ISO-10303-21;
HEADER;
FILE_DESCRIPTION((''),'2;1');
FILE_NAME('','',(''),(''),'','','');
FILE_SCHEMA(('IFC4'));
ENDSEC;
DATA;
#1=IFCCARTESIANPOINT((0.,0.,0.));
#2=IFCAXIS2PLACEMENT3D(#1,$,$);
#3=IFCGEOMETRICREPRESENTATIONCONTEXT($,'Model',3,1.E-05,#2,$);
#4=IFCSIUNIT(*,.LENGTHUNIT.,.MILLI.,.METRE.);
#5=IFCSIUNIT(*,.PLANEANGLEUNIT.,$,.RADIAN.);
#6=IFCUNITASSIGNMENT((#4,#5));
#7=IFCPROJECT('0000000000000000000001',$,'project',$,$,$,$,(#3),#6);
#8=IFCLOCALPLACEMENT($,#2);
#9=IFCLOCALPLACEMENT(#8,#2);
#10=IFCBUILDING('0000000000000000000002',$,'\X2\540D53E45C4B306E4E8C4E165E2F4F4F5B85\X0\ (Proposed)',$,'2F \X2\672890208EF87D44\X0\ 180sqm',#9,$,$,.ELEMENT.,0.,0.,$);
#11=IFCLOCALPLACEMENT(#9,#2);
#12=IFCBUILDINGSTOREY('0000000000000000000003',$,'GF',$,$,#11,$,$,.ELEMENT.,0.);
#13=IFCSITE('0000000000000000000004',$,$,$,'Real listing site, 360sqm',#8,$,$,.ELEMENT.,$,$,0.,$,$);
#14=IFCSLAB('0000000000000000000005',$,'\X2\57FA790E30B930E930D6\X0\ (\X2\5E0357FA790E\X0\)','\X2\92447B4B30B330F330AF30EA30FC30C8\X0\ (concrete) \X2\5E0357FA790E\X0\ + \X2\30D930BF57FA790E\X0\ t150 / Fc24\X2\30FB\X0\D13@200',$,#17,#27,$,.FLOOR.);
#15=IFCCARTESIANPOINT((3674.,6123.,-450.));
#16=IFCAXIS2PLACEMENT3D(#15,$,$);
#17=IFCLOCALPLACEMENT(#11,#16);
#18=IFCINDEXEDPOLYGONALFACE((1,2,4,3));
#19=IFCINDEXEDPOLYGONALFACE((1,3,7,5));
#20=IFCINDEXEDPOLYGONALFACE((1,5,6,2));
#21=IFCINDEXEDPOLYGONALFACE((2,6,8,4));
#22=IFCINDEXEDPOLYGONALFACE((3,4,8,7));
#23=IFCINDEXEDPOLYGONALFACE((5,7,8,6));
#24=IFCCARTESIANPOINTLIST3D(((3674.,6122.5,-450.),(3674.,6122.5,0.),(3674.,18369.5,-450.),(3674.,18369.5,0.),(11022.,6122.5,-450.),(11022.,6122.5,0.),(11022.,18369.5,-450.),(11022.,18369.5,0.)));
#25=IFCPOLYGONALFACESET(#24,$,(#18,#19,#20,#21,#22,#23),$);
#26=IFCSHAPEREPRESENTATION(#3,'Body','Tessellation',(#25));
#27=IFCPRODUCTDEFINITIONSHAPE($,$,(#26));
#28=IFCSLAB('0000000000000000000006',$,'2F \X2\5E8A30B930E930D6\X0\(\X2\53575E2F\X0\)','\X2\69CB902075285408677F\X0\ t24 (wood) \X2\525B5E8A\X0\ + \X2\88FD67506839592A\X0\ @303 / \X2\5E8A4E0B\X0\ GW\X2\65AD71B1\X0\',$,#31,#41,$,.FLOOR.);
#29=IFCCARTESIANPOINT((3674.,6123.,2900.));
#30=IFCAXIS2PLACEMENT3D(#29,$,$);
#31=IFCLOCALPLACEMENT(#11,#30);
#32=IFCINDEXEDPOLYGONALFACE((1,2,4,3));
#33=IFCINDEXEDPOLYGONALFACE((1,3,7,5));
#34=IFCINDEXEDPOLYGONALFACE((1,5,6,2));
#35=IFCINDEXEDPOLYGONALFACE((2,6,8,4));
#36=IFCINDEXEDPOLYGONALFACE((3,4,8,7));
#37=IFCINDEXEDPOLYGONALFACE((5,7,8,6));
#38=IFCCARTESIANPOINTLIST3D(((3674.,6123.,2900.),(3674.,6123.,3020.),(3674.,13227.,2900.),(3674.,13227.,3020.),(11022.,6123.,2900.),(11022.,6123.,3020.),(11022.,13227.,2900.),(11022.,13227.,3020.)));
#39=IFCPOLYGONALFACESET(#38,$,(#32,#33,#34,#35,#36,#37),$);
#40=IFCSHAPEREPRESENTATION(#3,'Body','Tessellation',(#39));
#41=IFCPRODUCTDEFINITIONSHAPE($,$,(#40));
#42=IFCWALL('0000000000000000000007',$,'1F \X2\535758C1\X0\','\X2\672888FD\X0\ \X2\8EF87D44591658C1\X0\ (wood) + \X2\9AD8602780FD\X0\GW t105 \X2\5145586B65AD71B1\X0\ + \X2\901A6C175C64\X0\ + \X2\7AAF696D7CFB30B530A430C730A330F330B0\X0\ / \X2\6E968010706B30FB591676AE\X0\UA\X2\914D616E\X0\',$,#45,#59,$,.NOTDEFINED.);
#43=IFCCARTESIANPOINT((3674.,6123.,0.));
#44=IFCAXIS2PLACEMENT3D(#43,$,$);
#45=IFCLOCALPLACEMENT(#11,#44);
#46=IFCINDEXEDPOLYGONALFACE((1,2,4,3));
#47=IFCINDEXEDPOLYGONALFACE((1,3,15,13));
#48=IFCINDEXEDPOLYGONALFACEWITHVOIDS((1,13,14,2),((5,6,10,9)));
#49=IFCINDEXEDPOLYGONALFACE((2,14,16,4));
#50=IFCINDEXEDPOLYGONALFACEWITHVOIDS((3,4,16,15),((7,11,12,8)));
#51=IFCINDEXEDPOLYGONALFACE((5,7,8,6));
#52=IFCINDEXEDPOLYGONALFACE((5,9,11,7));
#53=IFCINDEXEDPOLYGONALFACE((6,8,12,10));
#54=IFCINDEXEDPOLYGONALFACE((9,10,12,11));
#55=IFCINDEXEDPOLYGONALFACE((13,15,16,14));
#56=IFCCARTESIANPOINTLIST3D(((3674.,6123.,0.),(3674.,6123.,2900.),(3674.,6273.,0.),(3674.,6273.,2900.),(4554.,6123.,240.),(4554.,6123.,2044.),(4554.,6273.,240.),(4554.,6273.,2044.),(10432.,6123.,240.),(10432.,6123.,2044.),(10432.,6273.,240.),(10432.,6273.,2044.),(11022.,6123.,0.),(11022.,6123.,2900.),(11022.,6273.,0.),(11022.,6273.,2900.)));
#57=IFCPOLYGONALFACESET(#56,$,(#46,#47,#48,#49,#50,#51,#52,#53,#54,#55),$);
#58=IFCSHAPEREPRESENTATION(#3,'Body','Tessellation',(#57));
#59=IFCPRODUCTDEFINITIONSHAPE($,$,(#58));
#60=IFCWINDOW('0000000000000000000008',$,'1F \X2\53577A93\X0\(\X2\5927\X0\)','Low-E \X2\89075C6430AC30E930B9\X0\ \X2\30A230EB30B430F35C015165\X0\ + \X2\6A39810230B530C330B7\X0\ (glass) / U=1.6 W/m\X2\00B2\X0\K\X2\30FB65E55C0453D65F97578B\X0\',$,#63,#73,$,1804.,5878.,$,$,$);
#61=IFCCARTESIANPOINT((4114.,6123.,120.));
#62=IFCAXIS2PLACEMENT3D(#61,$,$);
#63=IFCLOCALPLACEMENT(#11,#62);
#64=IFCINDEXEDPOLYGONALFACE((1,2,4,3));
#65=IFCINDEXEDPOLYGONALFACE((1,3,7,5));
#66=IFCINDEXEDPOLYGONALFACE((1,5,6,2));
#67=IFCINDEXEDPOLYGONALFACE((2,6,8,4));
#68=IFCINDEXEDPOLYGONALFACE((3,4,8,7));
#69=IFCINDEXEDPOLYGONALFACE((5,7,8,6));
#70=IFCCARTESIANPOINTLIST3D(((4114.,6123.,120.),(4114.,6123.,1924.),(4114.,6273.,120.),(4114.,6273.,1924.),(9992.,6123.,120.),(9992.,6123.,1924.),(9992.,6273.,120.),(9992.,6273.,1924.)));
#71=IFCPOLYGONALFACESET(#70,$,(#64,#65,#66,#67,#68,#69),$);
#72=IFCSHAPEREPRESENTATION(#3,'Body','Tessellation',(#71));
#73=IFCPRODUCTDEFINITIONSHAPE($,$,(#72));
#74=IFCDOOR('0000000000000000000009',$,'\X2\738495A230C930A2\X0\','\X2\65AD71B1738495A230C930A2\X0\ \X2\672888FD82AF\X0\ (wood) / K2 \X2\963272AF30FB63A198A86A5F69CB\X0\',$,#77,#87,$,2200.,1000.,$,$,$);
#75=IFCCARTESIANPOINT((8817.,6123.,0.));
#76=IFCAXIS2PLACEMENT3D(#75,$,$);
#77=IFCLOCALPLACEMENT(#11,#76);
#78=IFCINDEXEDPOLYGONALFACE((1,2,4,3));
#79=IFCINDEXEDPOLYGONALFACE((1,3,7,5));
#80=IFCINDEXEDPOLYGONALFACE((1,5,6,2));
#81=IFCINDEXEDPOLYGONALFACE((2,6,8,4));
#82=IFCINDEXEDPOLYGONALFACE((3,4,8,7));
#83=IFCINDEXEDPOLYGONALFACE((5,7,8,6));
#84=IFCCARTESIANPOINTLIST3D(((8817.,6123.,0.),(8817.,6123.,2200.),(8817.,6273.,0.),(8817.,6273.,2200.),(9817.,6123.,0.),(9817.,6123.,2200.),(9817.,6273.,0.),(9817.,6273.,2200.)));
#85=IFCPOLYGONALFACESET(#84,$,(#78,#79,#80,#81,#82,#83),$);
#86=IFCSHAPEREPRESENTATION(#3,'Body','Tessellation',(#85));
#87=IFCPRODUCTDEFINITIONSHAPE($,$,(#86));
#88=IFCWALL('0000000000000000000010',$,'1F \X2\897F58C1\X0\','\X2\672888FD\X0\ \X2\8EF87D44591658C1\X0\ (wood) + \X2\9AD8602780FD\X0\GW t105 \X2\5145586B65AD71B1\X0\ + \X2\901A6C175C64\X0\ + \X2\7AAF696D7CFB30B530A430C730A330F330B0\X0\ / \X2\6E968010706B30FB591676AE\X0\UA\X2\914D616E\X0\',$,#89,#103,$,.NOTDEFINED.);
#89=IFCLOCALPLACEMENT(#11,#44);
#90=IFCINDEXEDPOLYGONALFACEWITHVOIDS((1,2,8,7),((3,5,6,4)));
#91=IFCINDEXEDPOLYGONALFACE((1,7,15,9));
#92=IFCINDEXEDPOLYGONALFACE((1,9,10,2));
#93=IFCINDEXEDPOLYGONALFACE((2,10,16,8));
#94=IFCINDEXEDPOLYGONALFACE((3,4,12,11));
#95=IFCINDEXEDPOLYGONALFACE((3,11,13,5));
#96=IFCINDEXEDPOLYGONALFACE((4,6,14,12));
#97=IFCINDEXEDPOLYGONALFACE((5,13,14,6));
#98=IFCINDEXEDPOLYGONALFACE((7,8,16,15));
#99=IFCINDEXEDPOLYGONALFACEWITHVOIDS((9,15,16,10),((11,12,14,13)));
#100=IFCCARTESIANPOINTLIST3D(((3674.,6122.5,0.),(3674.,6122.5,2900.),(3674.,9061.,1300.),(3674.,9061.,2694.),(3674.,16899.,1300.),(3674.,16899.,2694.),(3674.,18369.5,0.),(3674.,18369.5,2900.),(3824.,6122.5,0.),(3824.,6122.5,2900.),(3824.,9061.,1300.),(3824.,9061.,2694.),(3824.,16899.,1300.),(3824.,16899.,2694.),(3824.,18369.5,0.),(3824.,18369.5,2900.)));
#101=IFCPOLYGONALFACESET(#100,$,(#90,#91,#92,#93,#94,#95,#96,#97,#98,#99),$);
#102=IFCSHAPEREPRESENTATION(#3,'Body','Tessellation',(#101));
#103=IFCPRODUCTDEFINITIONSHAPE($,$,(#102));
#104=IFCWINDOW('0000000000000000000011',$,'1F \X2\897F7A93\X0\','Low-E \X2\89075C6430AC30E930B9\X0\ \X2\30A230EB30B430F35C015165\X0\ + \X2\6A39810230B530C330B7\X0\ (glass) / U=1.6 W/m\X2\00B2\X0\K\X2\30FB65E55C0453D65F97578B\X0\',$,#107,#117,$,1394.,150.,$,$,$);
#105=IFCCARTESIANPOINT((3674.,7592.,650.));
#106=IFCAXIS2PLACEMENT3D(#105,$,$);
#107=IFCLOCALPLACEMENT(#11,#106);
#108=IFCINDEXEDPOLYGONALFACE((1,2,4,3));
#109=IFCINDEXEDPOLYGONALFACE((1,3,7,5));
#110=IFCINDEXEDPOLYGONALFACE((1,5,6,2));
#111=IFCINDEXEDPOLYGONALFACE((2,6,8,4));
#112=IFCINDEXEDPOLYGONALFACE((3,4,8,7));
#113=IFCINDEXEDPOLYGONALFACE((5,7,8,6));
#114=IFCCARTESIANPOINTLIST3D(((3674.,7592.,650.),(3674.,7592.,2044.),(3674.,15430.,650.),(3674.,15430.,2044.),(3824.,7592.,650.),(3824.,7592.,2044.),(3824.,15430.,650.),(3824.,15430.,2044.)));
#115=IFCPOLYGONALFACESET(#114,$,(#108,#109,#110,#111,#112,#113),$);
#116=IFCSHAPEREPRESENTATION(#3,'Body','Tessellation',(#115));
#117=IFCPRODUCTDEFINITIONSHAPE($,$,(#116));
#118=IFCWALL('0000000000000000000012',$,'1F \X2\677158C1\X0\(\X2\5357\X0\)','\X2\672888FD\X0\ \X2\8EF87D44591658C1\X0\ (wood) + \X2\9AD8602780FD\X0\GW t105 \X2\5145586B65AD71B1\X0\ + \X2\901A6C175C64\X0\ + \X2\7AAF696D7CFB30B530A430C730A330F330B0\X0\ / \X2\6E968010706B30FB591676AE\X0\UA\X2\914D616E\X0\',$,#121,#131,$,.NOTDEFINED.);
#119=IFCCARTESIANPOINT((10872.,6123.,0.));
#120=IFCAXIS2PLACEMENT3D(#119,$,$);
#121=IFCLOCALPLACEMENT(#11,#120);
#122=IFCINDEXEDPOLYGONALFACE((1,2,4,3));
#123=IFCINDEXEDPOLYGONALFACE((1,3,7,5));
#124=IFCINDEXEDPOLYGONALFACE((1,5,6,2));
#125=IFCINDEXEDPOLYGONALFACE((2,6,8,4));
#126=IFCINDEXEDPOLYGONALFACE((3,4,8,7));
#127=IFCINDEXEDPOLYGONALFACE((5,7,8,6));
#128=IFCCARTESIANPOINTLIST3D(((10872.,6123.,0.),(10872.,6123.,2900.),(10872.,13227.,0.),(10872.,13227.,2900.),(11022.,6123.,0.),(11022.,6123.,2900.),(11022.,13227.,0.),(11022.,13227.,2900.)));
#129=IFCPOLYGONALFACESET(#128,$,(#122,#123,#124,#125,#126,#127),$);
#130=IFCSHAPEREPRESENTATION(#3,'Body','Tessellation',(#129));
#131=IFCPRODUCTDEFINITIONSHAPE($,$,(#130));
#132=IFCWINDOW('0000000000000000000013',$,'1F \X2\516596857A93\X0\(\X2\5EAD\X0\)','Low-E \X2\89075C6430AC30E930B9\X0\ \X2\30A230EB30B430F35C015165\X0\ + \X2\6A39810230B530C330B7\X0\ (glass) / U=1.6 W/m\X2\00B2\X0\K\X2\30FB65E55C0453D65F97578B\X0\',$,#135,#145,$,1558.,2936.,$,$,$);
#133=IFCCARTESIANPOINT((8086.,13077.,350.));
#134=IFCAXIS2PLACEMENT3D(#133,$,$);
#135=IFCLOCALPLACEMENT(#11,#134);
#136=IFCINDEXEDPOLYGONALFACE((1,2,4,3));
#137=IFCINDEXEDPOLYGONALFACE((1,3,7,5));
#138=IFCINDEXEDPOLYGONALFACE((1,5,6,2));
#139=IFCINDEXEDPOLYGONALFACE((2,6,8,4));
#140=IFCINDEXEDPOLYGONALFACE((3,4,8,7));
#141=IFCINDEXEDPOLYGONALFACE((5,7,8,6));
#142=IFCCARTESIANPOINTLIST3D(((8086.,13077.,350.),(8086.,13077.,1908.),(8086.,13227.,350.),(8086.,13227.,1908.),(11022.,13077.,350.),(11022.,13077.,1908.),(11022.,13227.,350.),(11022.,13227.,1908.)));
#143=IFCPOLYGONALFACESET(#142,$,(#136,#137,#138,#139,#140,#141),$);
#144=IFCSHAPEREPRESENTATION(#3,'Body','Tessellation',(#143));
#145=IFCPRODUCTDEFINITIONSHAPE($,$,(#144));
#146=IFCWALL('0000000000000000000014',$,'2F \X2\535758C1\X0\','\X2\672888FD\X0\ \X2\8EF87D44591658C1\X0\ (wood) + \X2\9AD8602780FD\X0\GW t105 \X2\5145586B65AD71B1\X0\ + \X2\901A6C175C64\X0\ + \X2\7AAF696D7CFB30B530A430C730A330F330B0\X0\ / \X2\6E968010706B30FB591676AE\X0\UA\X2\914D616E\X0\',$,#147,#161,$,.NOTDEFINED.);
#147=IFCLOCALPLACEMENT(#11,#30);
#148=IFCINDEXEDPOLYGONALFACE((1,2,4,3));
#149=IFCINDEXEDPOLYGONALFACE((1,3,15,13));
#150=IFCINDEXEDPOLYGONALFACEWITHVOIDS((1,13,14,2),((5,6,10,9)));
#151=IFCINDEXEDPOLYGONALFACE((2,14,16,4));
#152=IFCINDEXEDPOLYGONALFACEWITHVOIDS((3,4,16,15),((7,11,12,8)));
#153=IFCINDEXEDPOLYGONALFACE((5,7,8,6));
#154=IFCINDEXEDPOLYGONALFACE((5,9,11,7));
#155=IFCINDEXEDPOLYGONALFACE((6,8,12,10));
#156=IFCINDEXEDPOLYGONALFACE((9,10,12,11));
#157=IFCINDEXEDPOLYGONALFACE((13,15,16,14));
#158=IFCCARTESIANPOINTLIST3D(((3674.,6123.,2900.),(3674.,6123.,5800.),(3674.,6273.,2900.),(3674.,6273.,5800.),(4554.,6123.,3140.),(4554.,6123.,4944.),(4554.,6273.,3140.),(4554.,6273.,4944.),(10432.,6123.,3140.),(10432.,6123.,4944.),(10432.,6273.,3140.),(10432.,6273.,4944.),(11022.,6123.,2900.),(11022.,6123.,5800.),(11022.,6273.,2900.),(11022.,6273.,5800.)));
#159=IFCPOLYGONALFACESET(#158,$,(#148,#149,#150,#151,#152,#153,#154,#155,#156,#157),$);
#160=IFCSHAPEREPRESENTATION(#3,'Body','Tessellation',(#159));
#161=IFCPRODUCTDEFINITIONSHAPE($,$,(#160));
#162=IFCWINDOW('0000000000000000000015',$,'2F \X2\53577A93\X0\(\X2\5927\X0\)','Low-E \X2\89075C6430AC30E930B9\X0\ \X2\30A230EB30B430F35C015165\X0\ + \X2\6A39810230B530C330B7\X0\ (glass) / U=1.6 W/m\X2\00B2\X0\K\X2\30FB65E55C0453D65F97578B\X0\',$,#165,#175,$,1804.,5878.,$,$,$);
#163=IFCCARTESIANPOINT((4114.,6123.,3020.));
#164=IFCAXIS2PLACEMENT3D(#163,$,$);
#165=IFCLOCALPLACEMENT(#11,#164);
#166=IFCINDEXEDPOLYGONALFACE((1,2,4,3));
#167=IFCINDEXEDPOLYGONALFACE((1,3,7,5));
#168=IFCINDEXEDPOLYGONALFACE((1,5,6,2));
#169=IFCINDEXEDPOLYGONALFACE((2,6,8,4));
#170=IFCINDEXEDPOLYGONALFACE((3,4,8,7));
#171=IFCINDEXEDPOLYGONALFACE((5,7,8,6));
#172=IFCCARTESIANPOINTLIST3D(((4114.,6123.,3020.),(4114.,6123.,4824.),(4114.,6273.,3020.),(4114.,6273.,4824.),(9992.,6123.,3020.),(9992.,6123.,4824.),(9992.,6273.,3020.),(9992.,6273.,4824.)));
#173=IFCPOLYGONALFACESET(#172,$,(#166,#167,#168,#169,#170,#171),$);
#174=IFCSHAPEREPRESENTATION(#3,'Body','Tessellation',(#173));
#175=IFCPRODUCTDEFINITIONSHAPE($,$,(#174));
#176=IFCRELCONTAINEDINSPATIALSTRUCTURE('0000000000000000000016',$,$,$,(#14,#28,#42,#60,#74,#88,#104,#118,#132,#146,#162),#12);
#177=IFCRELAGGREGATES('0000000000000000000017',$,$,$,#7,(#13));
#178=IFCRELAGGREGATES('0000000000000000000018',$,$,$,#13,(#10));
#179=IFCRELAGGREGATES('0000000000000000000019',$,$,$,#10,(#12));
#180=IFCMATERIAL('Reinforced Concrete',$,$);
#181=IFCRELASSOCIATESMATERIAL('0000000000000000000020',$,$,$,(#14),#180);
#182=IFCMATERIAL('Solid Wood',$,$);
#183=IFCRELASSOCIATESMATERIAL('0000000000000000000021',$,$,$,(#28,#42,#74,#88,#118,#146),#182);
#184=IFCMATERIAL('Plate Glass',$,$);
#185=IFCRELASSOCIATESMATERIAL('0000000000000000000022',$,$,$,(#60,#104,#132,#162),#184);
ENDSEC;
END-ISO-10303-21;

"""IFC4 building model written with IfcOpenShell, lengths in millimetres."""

from ifc_helpers import new_model, si_unit, frame, frame_2d, origin, place, context, project, spatial, rectangle, extrude, material, element, fill, save


model = new_model("IFC4")

# Units and contexts
model_context = context("Model", 3, precision=1e-05, world=origin())
ifc_project = project(units=[si_unit("LENGTHUNIT", "METRE", prefix="MILLI"), si_unit("PLANEANGLEUNIT", "RADIAN")], contexts=[model_context])

# Site, building, storey
site_placement = place(None, origin())
site = spatial("IfcSite", under=ifc_project, at=site_placement, ObjectType="Real listing site, 360sqm", CompositionType="ELEMENT", RefElevation=0.0)
building_placement = place(site_placement, origin())
building = spatial("IfcBuilding", under=site, at=building_placement, Name="名古屋の二世帯住宅 (Proposed)", ObjectType="2F 木造軸組 180sqm", CompositionType="ELEMENT", ElevationOfRefHeight=0.0, ElevationOfTerrain=0.0)
storey_placement = place(building_placement, origin())
storey = spatial("IfcBuildingStorey", under=building, at=storey_placement, Name="GF", CompositionType="ELEMENT", Elevation=0.0)

# Slabs
ifc_material_1 = material(Name="Reinforced Concrete")
slab_1_placement = place(storey_placement, frame((3674.0, 6123.0, -450.0)))
element("IfcSlab", 1, at=slab_1_placement, inside=storey, material=ifc_material_1, Name="基礎スラブ (布基礎)", Description="鉄筋コンクリート (concrete) 布基礎 + ベタ基礎 t150 / Fc24・D13@200", PredefinedType="FLOOR", context=model_context, shape_type="SweptSolid", body=[
    extrude(rectangle(XDim=7348.0, YDim=12247.0, at=frame_2d((3674.0, 6123.0))), frame((3674.0, 6123.0, -450.0)), (0.0, 0.0, 1.0), 450.0),
])
ifc_material_2 = material(Name="Solid Wood")
slab_2_placement = place(storey_placement, frame((3674.0, 6123.0, 2900.0)))
element("IfcSlab", 2, at=slab_2_placement, inside=storey, material=ifc_material_2, Name="2F 床スラブ(南帯)", Description="構造用合板 t24 (wood) 剛床 + 製材根太 @303 / 床下 GW断熱", PredefinedType="FLOOR", context=model_context, shape_type="SweptSolid", body=[
    extrude(rectangle(XDim=7348.0, YDim=7104.0, at=frame_2d((3674.0, 3552.0))), frame((3674.0, 6123.0, 2900.0)), (0.0, 0.0, 1.0), 120.0),
])

# Wall, openings, window, door
wall_1_placement = place(storey_placement, frame((3674.0, 6123.0, 0.0)))
wall_1 = element("IfcWall", 3, at=wall_1_placement, inside=storey, material=ifc_material_2, Name="1F 南壁", Description="木製 軸組外壁 (wood) + 高性能GW t105 充填断熱 + 通気層 + 窯業系サイディング / 準耐火・外皮UA配慮", PredefinedType="NOTDEFINED", context=model_context, shape_type="SweptSolid", body=[
    extrude(rectangle(XDim=7348.0, YDim=150.0, at=frame_2d((3674.0, 75.0))), frame((3674.0, 6123.0, 0.0)), (0.0, 0.0, 1.0), 2900.0),
])
opening_1_placement = place(storey_placement, frame((4114.0, 6123.0, 120.0)))
opening_1 = element("IfcOpeningElement", 4, at=opening_1_placement, cuts=wall_1, PredefinedType="NOTDEFINED", context=model_context, shape_type="SweptSolid", body=[
    extrude(rectangle(XDim=5878.0, YDim=150.0, at=frame_2d((2939.0, 75.0))), frame((4114.0, 6123.0, 120.0)), (0.0, 0.0, 1.0), 1804.0),
])
opening_2_placement = place(storey_placement, frame((8817.0, 6123.0, 0.0)))
opening_2 = element("IfcOpeningElement", 5, at=opening_2_placement, cuts=wall_1, PredefinedType="NOTDEFINED", context=model_context, shape_type="SweptSolid", body=[
    extrude(rectangle(XDim=1000.0, YDim=150.0, at=frame_2d((500.0, 75.0))), frame((8817.0, 6123.0, 0.0)), (0.0, 0.0, 1.0), 2200.0),
])
ifc_material_3 = material(Name="Plate Glass")
window_1_placement = place(storey_placement, frame((4114.0, 6123.0, 120.0)))
window_1 = element("IfcWindow", 6, at=window_1_placement, inside=storey, material=ifc_material_3, Name="1F 南窓(大)", Description="Low-E 複層ガラス アルゴン封入 + 樹脂サッシ (glass) / U=1.6 W/m²K・日射取得型", OverallHeight=1804.0, OverallWidth=5878.0, context=model_context, shape_type="SweptSolid", body=[
    extrude(rectangle(XDim=5878.0, YDim=150.0, at=frame_2d((2939.0, 75.0))), frame((4114.0, 6123.0, 120.0)), (0.0, 0.0, 1.0), 1804.0),
])
fill(opening_1, window_1)
door_placement = place(storey_placement, frame((8817.0, 6123.0, 0.0)))
door = element("IfcDoor", 7, at=door_placement, inside=storey, material=ifc_material_2, Name="玄関ドア", Description="断熱玄関ドア 木製芯 (wood) / K2 防犯・採風機構", OverallHeight=2200.0, OverallWidth=1000.0, context=model_context, shape_type="SweptSolid", body=[
    extrude(rectangle(XDim=1000.0, YDim=150.0, at=frame_2d((500.0, 75.0))), frame((8817.0, 6123.0, 0.0)), (0.0, 0.0, 1.0), 2200.0),
])
fill(opening_2, door)

# Walls, openings, windows
wall_2_placement = place(storey_placement, frame((3674.0, 6123.0, 0.0)))
wall_2 = element("IfcWall", 8, at=wall_2_placement, inside=storey, material=ifc_material_2, Name="1F 西壁", Description="木製 軸組外壁 (wood) + 高性能GW t105 充填断熱 + 通気層 + 窯業系サイディング / 準耐火・外皮UA配慮", PredefinedType="NOTDEFINED", context=model_context, shape_type="SweptSolid", body=[
    extrude(rectangle(XDim=150.0, YDim=12247.0, at=frame_2d((75.0, 6123.0))), frame((3674.0, 6123.0, 0.0)), (0.0, 0.0, 1.0), 2900.0),
])
opening_3_placement = place(storey_placement, frame((3674.0, 7592.0, 650.0)))
opening_3 = element("IfcOpeningElement", 9, at=opening_3_placement, cuts=wall_2, PredefinedType="NOTDEFINED", context=model_context, shape_type="SweptSolid", body=[
    extrude(rectangle(XDim=150.0, YDim=7838.0, at=frame_2d((75.0, 3919.0))), frame((3674.0, 7592.0, 650.0)), (0.0, 0.0, 1.0), 1394.0),
])
window_2_placement = place(storey_placement, frame((3674.0, 7592.0, 650.0)))
window_2 = element("IfcWindow", 10, at=window_2_placement, inside=storey, material=ifc_material_3, Name="1F 西窓", Description="Low-E 複層ガラス アルゴン封入 + 樹脂サッシ (glass) / U=1.6 W/m²K・日射取得型", OverallHeight=1394.0, OverallWidth=150.0, context=model_context, shape_type="SweptSolid", body=[
    extrude(rectangle(XDim=150.0, YDim=7838.0, at=frame_2d((75.0, 3919.0))), frame((3674.0, 7592.0, 650.0)), (0.0, 0.0, 1.0), 1394.0),
])
fill(opening_3, window_2)
wall_3_placement = place(storey_placement, frame((10872.0, 6123.0, 0.0)))
wall_3 = element("IfcWall", 11, at=wall_3_placement, inside=storey, material=ifc_material_2, Name="1F 東壁(南)", Description="木製 軸組外壁 (wood) + 高性能GW t105 充填断熱 + 通気層 + 窯業系サイディング / 準耐火・外皮UA配慮", PredefinedType="NOTDEFINED", context=model_context, shape_type="SweptSolid", body=[
    extrude(rectangle(XDim=150.0, YDim=7104.0, at=frame_2d((75.0, 3552.0))), frame((10872.0, 6123.0, 0.0)), (0.0, 0.0, 1.0), 2900.0),
])
opening_4_placement = place(storey_placement, frame((8086.0, 13077.0, 350.0)))
opening_4 = element("IfcOpeningElement", 12, at=opening_4_placement, cuts=wall_3, PredefinedType="NOTDEFINED", context=model_context, shape_type="SweptSolid", body=[
    extrude(rectangle(XDim=2936.0, YDim=150.0, at=frame_2d((1468.0, 75.0))), frame((8086.0, 13077.0, 350.0)), (0.0, 0.0, 1.0), 1558.0),
])
window_3_placement = place(storey_placement, frame((8086.0, 13077.0, 350.0)))
window_3 = element("IfcWindow", 13, at=window_3_placement, inside=storey, material=ifc_material_3, Name="1F 入隅窓(庭)", Description="Low-E 複層ガラス アルゴン封入 + 樹脂サッシ (glass) / U=1.6 W/m²K・日射取得型", OverallHeight=1558.0, OverallWidth=2936.0, context=model_context, shape_type="SweptSolid", body=[
    extrude(rectangle(XDim=2936.0, YDim=150.0, at=frame_2d((1468.0, 75.0))), frame((8086.0, 13077.0, 350.0)), (0.0, 0.0, 1.0), 1558.0),
])
fill(opening_4, window_3)

# Wall, opening, window
wall_4_placement = place(storey_placement, frame((3674.0, 6123.0, 2900.0)))
wall_4 = element("IfcWall", 14, at=wall_4_placement, inside=storey, material=ifc_material_2, Name="2F 南壁", Description="木製 軸組外壁 (wood) + 高性能GW t105 充填断熱 + 通気層 + 窯業系サイディング / 準耐火・外皮UA配慮", PredefinedType="NOTDEFINED", context=model_context, shape_type="SweptSolid", body=[
    extrude(rectangle(XDim=7348.0, YDim=150.0, at=frame_2d((3674.0, 75.0))), frame((3674.0, 6123.0, 2900.0)), (0.0, 0.0, 1.0), 2900.0),
])
opening_5_placement = place(storey_placement, frame((4114.0, 6123.0, 3020.0)))
opening_5 = element("IfcOpeningElement", 15, at=opening_5_placement, cuts=wall_4, PredefinedType="NOTDEFINED", context=model_context, shape_type="SweptSolid", body=[
    extrude(rectangle(XDim=5878.0, YDim=150.0, at=frame_2d((2939.0, 75.0))), frame((4114.0, 6123.0, 3020.0)), (0.0, 0.0, 1.0), 1804.0),
])
window_4_placement = place(storey_placement, frame((4114.0, 6123.0, 3020.0)))
window_4 = element("IfcWindow", 16, at=window_4_placement, inside=storey, material=ifc_material_3, Name="2F 南窓(大)", Description="Low-E 複層ガラス アルゴン封入 + 樹脂サッシ (glass) / U=1.6 W/m²K・日射取得型", OverallHeight=1804.0, OverallWidth=5878.0, context=model_context, shape_type="SweptSolid", body=[
    extrude(rectangle(XDim=5878.0, YDim=150.0, at=frame_2d((2939.0, 75.0))), frame((4114.0, 6123.0, 3020.0)), (0.0, 0.0, 1.0), 1804.0),
])
fill(opening_5, window_4)

save(model, "model.ifc")
